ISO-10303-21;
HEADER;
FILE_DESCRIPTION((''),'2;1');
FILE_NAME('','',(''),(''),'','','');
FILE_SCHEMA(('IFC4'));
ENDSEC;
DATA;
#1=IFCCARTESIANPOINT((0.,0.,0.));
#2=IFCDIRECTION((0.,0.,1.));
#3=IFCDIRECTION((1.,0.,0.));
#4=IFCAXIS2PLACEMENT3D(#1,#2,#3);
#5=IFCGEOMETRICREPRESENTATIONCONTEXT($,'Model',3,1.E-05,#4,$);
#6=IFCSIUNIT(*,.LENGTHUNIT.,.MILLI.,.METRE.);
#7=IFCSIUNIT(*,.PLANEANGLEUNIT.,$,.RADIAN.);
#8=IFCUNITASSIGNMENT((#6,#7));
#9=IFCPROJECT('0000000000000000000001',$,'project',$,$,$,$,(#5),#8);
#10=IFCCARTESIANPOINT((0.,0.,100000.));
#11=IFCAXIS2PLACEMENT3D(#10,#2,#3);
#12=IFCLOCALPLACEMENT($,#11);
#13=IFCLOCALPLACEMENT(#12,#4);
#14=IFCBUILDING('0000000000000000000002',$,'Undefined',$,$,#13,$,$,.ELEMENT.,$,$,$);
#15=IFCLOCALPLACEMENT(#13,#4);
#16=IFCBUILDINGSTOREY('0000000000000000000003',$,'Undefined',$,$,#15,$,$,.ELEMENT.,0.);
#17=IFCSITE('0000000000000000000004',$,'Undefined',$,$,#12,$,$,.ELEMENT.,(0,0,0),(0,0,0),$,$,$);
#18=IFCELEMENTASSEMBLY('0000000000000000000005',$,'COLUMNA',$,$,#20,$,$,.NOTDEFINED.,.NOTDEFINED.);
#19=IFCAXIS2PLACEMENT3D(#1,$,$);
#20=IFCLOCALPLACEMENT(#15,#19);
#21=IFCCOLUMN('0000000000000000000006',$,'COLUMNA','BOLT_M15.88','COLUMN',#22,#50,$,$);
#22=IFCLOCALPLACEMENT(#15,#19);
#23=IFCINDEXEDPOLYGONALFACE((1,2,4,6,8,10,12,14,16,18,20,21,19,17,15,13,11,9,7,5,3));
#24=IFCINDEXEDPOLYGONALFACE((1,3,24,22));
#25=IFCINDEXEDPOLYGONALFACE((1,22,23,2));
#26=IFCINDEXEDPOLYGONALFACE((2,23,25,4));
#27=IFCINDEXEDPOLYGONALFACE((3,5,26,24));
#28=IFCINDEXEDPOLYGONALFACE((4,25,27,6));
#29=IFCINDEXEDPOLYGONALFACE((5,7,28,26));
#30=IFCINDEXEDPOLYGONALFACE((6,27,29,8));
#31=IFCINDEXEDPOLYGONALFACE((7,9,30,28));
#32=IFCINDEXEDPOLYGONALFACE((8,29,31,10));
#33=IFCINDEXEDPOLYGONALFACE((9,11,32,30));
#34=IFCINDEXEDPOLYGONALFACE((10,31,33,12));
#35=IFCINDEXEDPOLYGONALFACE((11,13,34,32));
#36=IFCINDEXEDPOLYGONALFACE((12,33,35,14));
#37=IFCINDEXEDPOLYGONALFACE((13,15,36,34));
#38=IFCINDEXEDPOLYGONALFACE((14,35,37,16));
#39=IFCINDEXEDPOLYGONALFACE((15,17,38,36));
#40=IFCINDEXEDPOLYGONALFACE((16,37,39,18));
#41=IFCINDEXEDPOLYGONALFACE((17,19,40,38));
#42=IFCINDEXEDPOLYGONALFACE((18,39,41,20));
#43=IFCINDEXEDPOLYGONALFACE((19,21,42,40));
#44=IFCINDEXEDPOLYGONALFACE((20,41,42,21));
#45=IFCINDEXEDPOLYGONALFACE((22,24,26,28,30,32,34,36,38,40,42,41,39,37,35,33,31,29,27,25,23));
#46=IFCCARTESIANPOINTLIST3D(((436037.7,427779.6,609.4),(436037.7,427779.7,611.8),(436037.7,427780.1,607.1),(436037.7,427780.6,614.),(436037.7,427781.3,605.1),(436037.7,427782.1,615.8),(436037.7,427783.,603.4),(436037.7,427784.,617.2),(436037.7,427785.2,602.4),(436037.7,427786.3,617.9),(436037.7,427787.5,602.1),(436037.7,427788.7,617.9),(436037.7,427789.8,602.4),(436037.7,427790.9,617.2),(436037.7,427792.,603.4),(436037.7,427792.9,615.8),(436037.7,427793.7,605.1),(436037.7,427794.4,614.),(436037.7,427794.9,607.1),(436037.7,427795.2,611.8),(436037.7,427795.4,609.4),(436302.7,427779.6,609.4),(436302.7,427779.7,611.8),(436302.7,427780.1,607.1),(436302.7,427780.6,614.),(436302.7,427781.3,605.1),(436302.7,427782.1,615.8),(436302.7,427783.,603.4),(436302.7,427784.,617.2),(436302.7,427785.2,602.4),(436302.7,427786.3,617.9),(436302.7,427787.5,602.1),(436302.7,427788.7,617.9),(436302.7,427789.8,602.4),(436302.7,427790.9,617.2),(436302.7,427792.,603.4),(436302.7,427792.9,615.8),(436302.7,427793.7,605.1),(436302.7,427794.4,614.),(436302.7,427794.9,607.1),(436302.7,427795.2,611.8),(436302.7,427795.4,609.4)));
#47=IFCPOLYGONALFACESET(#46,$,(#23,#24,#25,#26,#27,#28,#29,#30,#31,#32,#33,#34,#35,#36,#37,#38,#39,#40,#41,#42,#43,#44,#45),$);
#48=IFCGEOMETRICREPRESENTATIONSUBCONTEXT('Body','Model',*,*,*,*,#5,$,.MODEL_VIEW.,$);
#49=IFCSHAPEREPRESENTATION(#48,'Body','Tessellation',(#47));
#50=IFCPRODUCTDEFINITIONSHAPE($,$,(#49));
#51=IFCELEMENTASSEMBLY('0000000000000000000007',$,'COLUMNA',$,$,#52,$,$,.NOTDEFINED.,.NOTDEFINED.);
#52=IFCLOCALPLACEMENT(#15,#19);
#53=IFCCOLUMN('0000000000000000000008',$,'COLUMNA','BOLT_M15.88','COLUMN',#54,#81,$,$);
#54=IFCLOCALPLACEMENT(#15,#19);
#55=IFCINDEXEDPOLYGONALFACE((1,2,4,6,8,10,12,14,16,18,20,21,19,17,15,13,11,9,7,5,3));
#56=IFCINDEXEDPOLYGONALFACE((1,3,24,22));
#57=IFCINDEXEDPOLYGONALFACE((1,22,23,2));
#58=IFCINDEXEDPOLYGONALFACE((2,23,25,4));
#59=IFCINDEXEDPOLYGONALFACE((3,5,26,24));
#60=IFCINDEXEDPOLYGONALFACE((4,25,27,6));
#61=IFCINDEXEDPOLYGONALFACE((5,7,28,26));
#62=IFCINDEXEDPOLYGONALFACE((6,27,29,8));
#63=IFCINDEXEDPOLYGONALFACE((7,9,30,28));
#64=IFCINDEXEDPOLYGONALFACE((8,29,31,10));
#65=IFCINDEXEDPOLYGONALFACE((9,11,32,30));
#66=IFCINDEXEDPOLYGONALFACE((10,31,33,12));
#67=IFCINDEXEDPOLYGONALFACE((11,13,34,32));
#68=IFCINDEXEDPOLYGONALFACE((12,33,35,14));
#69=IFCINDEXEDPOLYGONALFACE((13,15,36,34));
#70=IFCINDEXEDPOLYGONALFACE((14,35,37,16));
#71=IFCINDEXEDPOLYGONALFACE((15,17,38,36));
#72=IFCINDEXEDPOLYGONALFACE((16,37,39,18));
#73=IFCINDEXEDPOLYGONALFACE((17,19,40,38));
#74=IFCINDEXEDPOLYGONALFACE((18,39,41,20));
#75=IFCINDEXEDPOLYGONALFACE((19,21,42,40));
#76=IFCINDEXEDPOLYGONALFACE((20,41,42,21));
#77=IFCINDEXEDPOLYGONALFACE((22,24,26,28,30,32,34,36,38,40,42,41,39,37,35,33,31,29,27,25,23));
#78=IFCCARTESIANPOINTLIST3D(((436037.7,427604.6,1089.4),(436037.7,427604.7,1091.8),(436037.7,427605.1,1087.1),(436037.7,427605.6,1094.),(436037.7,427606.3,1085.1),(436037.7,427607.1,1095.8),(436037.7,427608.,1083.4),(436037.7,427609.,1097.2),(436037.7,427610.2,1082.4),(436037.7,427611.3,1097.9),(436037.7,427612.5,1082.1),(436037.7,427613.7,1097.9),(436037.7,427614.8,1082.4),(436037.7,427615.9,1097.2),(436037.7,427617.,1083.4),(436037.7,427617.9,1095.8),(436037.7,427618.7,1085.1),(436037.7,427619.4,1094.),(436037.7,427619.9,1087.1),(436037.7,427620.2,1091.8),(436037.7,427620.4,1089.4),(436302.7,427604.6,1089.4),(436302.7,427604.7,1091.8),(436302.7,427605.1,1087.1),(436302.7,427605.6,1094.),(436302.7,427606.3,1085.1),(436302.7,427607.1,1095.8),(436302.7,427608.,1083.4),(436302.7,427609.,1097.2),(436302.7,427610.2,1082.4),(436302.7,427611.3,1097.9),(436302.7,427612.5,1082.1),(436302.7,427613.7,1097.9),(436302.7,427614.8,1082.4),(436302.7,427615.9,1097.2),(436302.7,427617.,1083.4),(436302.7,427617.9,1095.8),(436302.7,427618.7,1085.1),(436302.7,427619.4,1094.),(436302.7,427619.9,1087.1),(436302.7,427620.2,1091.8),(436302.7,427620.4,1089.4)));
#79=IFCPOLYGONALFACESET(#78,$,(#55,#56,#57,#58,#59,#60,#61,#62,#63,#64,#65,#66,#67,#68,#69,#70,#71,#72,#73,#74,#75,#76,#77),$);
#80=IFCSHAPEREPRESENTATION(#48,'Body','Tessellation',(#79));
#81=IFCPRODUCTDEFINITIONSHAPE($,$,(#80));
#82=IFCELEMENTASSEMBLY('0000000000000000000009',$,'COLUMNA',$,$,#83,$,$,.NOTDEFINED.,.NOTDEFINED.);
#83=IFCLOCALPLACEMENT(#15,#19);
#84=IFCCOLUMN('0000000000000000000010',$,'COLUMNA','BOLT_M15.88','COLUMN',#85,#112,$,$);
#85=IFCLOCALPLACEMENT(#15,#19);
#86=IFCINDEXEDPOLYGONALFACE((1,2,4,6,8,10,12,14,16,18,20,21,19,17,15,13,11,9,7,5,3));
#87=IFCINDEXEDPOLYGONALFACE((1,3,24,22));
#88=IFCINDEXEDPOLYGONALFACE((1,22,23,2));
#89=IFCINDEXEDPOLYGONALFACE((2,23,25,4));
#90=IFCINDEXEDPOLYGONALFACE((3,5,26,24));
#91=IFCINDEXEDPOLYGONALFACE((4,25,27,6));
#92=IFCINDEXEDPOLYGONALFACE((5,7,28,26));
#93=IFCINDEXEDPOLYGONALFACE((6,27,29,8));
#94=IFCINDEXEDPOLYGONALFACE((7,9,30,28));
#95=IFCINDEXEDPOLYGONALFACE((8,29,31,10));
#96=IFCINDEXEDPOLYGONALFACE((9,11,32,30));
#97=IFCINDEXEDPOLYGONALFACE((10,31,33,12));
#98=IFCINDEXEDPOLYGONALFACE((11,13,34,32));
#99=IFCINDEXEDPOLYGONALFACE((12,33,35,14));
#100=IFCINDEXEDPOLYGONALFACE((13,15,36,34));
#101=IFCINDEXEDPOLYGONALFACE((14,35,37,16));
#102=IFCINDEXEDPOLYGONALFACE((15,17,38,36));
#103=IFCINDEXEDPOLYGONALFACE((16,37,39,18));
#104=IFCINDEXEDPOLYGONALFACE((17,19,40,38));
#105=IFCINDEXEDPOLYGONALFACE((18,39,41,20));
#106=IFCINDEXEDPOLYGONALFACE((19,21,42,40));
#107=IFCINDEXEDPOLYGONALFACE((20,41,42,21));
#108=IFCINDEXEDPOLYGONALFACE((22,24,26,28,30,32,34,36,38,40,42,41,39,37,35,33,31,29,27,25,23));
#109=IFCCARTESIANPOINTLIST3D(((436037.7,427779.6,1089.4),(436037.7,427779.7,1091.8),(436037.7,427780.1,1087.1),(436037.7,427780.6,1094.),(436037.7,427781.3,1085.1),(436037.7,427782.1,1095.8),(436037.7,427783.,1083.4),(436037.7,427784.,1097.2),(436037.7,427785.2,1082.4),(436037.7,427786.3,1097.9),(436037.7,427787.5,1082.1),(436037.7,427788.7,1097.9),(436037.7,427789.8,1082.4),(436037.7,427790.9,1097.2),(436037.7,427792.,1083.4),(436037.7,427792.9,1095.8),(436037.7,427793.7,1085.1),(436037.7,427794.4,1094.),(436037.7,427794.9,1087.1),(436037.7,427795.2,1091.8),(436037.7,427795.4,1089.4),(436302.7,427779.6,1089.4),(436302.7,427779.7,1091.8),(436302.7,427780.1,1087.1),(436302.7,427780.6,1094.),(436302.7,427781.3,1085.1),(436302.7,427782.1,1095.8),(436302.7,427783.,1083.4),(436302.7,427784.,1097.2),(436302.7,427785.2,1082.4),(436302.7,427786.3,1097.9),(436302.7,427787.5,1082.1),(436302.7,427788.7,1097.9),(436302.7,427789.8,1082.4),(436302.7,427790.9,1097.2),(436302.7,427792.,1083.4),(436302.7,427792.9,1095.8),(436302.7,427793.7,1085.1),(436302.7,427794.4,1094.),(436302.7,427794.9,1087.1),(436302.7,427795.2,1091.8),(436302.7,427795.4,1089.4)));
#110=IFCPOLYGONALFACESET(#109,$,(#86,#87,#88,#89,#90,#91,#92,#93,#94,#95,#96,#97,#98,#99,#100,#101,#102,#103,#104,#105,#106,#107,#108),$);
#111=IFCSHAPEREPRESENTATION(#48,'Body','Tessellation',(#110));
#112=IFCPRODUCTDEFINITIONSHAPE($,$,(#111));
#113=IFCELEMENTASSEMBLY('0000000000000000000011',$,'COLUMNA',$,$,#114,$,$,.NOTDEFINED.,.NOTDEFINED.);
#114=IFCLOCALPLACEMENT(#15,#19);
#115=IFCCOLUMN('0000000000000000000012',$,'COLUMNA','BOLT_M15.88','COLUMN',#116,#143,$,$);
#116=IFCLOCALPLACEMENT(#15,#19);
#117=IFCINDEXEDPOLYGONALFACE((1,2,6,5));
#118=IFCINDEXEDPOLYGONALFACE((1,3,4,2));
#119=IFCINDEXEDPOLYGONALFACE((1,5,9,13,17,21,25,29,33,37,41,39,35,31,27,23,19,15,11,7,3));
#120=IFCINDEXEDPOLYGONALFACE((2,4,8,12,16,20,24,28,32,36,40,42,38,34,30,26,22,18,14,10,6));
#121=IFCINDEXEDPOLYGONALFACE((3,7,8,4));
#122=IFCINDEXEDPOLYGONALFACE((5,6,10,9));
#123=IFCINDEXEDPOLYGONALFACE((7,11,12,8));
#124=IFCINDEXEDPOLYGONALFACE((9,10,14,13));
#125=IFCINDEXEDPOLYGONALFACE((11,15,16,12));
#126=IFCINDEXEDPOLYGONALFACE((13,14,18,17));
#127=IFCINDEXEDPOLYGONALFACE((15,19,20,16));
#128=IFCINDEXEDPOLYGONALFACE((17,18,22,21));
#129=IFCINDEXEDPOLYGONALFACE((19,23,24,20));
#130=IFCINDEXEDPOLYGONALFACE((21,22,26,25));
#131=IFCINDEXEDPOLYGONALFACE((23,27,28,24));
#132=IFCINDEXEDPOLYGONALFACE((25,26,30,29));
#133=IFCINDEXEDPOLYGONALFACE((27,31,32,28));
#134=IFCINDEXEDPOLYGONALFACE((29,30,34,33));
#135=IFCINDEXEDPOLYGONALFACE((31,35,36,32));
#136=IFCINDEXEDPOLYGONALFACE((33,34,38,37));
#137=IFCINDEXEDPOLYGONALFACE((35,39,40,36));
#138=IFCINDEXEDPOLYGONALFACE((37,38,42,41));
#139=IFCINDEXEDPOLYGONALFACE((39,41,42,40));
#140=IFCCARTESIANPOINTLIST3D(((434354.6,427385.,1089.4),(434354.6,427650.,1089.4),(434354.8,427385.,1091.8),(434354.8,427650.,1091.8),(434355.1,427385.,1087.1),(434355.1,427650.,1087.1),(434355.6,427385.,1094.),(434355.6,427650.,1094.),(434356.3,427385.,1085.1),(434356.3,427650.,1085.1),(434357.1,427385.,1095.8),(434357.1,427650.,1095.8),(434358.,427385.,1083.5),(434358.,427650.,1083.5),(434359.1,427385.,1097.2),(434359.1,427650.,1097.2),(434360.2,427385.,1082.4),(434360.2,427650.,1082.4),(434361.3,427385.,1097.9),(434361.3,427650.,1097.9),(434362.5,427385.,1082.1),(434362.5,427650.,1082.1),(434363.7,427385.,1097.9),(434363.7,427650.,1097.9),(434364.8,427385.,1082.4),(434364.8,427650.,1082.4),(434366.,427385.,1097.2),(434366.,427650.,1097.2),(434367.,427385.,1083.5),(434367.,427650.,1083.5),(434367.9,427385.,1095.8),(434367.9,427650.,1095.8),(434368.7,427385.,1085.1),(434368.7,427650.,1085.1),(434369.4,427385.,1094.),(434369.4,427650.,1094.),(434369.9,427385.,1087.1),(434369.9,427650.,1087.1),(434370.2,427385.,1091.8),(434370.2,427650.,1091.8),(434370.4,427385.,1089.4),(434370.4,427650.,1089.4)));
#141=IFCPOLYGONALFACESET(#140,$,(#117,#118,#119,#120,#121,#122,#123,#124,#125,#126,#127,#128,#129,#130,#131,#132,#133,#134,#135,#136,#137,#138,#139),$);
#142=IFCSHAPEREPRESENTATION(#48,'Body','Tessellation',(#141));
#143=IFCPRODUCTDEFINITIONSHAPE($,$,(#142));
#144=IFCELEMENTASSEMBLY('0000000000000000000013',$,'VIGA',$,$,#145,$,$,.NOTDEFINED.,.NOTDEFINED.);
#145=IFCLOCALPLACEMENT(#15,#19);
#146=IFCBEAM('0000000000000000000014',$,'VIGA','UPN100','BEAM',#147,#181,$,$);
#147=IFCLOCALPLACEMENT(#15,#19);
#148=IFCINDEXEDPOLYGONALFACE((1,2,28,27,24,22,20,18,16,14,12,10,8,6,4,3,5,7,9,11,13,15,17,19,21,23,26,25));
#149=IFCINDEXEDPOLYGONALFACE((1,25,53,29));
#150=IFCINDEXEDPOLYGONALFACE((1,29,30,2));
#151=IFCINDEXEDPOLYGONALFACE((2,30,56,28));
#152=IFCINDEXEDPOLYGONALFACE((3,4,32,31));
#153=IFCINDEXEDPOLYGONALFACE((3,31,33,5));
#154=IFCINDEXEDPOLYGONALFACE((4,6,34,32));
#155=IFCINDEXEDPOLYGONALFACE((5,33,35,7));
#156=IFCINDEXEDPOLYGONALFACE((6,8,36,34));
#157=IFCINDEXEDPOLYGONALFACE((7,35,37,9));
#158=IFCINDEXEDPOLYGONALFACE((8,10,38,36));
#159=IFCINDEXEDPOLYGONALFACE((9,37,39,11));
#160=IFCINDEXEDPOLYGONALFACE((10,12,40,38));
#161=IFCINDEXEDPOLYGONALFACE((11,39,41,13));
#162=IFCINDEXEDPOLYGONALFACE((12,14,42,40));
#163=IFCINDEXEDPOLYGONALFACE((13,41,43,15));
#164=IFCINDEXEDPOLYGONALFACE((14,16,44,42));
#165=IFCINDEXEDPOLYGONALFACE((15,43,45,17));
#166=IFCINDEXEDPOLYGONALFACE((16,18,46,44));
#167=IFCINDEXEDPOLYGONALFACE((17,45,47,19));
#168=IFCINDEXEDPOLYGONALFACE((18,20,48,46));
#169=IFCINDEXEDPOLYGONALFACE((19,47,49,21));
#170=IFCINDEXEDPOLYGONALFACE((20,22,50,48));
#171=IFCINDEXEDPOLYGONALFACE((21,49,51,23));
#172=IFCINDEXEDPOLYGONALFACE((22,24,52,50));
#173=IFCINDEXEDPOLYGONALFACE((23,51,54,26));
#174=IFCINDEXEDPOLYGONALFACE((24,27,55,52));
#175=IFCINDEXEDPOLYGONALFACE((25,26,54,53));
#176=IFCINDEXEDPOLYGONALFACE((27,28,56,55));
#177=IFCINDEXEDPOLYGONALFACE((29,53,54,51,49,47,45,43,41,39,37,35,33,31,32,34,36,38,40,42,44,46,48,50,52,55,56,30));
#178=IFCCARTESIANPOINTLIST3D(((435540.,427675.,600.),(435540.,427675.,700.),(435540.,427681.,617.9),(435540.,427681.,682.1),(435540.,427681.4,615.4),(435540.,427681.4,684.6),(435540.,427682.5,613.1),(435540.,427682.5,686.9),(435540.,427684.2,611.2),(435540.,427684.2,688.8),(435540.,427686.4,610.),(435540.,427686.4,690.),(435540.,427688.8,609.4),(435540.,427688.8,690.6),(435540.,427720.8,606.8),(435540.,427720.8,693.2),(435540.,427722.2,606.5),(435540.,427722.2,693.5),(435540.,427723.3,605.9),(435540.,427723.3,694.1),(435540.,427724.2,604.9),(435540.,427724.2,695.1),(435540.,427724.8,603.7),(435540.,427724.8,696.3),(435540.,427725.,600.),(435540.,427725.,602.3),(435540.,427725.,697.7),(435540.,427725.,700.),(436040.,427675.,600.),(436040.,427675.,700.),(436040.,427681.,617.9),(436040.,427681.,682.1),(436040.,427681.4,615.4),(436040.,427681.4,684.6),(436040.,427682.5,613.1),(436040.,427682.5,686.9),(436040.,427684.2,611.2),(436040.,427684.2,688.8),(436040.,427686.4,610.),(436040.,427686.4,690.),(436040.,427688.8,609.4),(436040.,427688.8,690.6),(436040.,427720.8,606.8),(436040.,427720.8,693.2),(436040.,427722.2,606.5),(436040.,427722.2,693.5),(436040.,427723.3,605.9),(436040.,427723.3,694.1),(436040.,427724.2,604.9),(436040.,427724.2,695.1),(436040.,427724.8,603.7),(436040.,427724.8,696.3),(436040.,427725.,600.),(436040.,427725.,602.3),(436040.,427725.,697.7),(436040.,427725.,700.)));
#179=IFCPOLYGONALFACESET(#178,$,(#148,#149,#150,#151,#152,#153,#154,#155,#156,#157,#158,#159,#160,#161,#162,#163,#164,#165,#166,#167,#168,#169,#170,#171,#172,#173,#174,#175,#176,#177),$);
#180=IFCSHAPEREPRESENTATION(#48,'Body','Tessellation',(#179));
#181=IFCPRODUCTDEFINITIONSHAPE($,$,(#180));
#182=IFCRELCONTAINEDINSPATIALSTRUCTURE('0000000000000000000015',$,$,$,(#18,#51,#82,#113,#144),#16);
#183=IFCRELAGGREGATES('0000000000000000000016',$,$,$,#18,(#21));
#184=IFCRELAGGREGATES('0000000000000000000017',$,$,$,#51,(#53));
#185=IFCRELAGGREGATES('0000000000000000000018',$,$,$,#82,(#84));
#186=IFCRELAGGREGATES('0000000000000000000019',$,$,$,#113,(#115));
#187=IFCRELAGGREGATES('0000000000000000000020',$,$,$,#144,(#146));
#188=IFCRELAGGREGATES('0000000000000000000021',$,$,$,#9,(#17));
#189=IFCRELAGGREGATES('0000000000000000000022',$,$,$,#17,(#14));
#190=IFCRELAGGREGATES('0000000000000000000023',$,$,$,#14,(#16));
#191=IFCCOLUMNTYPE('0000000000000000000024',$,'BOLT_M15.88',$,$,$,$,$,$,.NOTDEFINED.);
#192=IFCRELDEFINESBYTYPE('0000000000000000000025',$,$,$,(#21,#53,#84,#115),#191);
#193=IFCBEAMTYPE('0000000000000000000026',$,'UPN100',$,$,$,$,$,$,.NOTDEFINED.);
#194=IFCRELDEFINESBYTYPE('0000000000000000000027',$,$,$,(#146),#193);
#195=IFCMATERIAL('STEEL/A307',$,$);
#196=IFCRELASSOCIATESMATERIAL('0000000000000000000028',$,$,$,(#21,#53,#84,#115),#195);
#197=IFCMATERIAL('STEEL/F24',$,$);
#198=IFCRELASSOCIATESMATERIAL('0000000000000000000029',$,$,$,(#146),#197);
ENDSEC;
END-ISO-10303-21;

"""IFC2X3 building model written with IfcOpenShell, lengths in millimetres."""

from ifc_helpers import new_model, si_unit, frame, origin_with_axes, origin_2d_with_axis, place, context, subcontext, project, spatial, circle, u_section, extrude, material, type_object, element, aggregate, save


model = new_model("IFC2X3")

# Units and contexts
model_context = context("Model", 3, precision=1e-05, world=origin_with_axes())
body_context = subcontext(model_context, "Body", "Model", "MODEL_VIEW")
ifc_project = project(units=[si_unit("LENGTHUNIT", "METRE", prefix="MILLI"), si_unit("PLANEANGLEUNIT", "RADIAN")], contexts=[model_context])

# Site, building, storey
site_placement = place(None, frame((0.0, 0.0, 100000.0), z_axis=(0.0, 0.0, 1.0), x_axis=(1.0, 0.0, 0.0)))
site = spatial("IfcSite", under=ifc_project, at=site_placement, Name="Undefined", CompositionType="ELEMENT", RefLatitude=(0, 0, 0), RefLongitude=(0, 0, 0))
building_placement = place(site_placement, origin_with_axes())
building = spatial("IfcBuilding", under=site, at=building_placement, Name="Undefined", CompositionType="ELEMENT")
storey_placement = place(building_placement, origin_with_axes())
storey = spatial("IfcBuildingStorey", under=building, at=storey_placement, Name="Undefined", CompositionType="ELEMENT", Elevation=0.0)

# Element assemblies, columns
ifc_material_1 = material(Name="STEEL/A307")
column_type_1 = type_object("IfcColumnType", Name="BOLT_M15.88", PredefinedType="NOTDEFINED")
assembly_1_placement = place(storey_placement, origin_with_axes())
assembly_1 = element("IfcElementAssembly", 1, at=assembly_1_placement, inside=storey, Name="COLUMNA", AssemblyPlace="NOTDEFINED", PredefinedType="NOTDEFINED")
column_1_placement = place(assembly_1_placement, frame((436302.7, 427787.5, 610.0), z_axis=(-1.0, 0.0, -0.000003), x_axis=(0.0, 1.0, 0.0)))
column_1 = element("IfcColumn", 2, at=column_1_placement, type_object=column_type_1, material=ifc_material_1, Name="COLUMNA", Description="BOLT_M15.88", ObjectType="COLUMN", context=body_context, shape_type="SweptSolid", body=[
    extrude(circle(Radius=7.9, at=origin_2d_with_axis()), frame((0.0, 0.0, 265.0), z_axis=(0.0, 0.0, -1.0), x_axis=(0.0, 1.0, 0.0)), (0.0, 0.0, 1.0), 265.0),
])
aggregate(assembly_1, [column_1])
assembly_2_placement = place(storey_placement, origin_with_axes())
assembly_2 = element("IfcElementAssembly", 3, at=assembly_2_placement, inside=storey, Name="COLUMNA", AssemblyPlace="NOTDEFINED", PredefinedType="NOTDEFINED")
column_2_placement = place(assembly_2_placement, frame((436302.7, 427612.5, 1090.0), z_axis=(-1.0, 0.0, -0.000003), x_axis=(0.0, 1.0, 0.0)))
column_2 = element("IfcColumn", 4, at=column_2_placement, type_object=column_type_1, material=ifc_material_1, Name="COLUMNA", Description="BOLT_M15.88", ObjectType="COLUMN", context=body_context, shape_type="SweptSolid", body=[
    extrude(circle(Radius=7.9, at=origin_2d_with_axis()), frame((0.0, 0.0, 265.0), z_axis=(0.0, 0.0, -1.0), x_axis=(0.0, 1.0, 0.0)), (0.0, 0.0, 1.0), 265.0),
])
aggregate(assembly_2, [column_2])
assembly_3_placement = place(storey_placement, origin_with_axes())
assembly_3 = element("IfcElementAssembly", 5, at=assembly_3_placement, inside=storey, Name="COLUMNA", AssemblyPlace="NOTDEFINED", PredefinedType="NOTDEFINED")
column_3_placement = place(assembly_3_placement, frame((436302.7, 427787.5, 1090.0), z_axis=(-1.0, 0.0, -0.000003), x_axis=(0.0, 1.0, 0.0)))
column_3 = element("IfcColumn", 6, at=column_3_placement, type_object=column_type_1, material=ifc_material_1, Name="COLUMNA", Description="BOLT_M15.88", ObjectType="COLUMN", context=body_context, shape_type="SweptSolid", body=[
    extrude(circle(Radius=7.9, at=origin_2d_with_axis()), frame((0.0, 0.0, 265.0), z_axis=(0.0, 0.0, -1.0), x_axis=(0.0, 1.0, 0.0)), (0.0, 0.0, 1.0), 265.0),
])
aggregate(assembly_3, [column_3])
assembly_4_placement = place(storey_placement, origin_with_axes())
assembly_4 = element("IfcElementAssembly", 7, at=assembly_4_placement, inside=storey, Name="COLUMNA", AssemblyPlace="NOTDEFINED", PredefinedType="NOTDEFINED")
column_4_placement = place(assembly_4_placement, frame((434362.5, 427650.0, 1090.0), z_axis=(0.0, -1.0, -0.000003), x_axis=(-1.0, 0.0, 0.0)))
column_4 = element("IfcColumn", 8, at=column_4_placement, type_object=column_type_1, material=ifc_material_1, Name="COLUMNA", Description="BOLT_M15.88", ObjectType="COLUMN", context=body_context, shape_type="SweptSolid", body=[
    extrude(circle(Radius=7.9, at=origin_2d_with_axis()), frame((0.0, 0.0, 265.0), z_axis=(0.0, 0.0, -1.0), x_axis=(0.0, 1.0, 0.0)), (0.0, 0.0, 1.0), 265.0),
])
aggregate(assembly_4, [column_4])

# Element assembly, beam
assembly_5_placement = place(storey_placement, origin_with_axes())
assembly_5 = element("IfcElementAssembly", 9, at=assembly_5_placement, inside=storey, Name="VIGA", AssemblyPlace="NOTDEFINED", PredefinedType="NOTDEFINED")
ifc_material_2 = material(Name="STEEL/F24")
beam_type = type_object("IfcBeamType", Name="UPN100", PredefinedType="NOTDEFINED")
beam_1_placement = place(assembly_5_placement, frame((436040.0, 427700.0, 650.0), z_axis=(0.0, 0.0, 1.0), x_axis=(-1.0, 0.0, 0.0)))
beam_1 = element("IfcBeam", 10, at=beam_1_placement, type_object=beam_type, material=ifc_material_2, Name="VIGA", Description="UPN100", ObjectType="BEAM", context=body_context, shape_type="SweptSolid", body=[
    extrude(u_section(Depth=100.0, FlangeWidth=50.0, WebThickness=6.0, FlangeThickness=8.5, FilletRadius=8.5, EdgeRadius=4.5, FlangeSlope=0.07983, at=origin_2d_with_axis()), frame((500.0, 0.0, 0.0), z_axis=(-1.0, 0.0, 0.0), x_axis=(0.0, -1.0, 0.0)), (0.0, 0.0, 1.0), 500.0),
])
aggregate(assembly_5, [beam_1])

save(model, "model.ifc")
